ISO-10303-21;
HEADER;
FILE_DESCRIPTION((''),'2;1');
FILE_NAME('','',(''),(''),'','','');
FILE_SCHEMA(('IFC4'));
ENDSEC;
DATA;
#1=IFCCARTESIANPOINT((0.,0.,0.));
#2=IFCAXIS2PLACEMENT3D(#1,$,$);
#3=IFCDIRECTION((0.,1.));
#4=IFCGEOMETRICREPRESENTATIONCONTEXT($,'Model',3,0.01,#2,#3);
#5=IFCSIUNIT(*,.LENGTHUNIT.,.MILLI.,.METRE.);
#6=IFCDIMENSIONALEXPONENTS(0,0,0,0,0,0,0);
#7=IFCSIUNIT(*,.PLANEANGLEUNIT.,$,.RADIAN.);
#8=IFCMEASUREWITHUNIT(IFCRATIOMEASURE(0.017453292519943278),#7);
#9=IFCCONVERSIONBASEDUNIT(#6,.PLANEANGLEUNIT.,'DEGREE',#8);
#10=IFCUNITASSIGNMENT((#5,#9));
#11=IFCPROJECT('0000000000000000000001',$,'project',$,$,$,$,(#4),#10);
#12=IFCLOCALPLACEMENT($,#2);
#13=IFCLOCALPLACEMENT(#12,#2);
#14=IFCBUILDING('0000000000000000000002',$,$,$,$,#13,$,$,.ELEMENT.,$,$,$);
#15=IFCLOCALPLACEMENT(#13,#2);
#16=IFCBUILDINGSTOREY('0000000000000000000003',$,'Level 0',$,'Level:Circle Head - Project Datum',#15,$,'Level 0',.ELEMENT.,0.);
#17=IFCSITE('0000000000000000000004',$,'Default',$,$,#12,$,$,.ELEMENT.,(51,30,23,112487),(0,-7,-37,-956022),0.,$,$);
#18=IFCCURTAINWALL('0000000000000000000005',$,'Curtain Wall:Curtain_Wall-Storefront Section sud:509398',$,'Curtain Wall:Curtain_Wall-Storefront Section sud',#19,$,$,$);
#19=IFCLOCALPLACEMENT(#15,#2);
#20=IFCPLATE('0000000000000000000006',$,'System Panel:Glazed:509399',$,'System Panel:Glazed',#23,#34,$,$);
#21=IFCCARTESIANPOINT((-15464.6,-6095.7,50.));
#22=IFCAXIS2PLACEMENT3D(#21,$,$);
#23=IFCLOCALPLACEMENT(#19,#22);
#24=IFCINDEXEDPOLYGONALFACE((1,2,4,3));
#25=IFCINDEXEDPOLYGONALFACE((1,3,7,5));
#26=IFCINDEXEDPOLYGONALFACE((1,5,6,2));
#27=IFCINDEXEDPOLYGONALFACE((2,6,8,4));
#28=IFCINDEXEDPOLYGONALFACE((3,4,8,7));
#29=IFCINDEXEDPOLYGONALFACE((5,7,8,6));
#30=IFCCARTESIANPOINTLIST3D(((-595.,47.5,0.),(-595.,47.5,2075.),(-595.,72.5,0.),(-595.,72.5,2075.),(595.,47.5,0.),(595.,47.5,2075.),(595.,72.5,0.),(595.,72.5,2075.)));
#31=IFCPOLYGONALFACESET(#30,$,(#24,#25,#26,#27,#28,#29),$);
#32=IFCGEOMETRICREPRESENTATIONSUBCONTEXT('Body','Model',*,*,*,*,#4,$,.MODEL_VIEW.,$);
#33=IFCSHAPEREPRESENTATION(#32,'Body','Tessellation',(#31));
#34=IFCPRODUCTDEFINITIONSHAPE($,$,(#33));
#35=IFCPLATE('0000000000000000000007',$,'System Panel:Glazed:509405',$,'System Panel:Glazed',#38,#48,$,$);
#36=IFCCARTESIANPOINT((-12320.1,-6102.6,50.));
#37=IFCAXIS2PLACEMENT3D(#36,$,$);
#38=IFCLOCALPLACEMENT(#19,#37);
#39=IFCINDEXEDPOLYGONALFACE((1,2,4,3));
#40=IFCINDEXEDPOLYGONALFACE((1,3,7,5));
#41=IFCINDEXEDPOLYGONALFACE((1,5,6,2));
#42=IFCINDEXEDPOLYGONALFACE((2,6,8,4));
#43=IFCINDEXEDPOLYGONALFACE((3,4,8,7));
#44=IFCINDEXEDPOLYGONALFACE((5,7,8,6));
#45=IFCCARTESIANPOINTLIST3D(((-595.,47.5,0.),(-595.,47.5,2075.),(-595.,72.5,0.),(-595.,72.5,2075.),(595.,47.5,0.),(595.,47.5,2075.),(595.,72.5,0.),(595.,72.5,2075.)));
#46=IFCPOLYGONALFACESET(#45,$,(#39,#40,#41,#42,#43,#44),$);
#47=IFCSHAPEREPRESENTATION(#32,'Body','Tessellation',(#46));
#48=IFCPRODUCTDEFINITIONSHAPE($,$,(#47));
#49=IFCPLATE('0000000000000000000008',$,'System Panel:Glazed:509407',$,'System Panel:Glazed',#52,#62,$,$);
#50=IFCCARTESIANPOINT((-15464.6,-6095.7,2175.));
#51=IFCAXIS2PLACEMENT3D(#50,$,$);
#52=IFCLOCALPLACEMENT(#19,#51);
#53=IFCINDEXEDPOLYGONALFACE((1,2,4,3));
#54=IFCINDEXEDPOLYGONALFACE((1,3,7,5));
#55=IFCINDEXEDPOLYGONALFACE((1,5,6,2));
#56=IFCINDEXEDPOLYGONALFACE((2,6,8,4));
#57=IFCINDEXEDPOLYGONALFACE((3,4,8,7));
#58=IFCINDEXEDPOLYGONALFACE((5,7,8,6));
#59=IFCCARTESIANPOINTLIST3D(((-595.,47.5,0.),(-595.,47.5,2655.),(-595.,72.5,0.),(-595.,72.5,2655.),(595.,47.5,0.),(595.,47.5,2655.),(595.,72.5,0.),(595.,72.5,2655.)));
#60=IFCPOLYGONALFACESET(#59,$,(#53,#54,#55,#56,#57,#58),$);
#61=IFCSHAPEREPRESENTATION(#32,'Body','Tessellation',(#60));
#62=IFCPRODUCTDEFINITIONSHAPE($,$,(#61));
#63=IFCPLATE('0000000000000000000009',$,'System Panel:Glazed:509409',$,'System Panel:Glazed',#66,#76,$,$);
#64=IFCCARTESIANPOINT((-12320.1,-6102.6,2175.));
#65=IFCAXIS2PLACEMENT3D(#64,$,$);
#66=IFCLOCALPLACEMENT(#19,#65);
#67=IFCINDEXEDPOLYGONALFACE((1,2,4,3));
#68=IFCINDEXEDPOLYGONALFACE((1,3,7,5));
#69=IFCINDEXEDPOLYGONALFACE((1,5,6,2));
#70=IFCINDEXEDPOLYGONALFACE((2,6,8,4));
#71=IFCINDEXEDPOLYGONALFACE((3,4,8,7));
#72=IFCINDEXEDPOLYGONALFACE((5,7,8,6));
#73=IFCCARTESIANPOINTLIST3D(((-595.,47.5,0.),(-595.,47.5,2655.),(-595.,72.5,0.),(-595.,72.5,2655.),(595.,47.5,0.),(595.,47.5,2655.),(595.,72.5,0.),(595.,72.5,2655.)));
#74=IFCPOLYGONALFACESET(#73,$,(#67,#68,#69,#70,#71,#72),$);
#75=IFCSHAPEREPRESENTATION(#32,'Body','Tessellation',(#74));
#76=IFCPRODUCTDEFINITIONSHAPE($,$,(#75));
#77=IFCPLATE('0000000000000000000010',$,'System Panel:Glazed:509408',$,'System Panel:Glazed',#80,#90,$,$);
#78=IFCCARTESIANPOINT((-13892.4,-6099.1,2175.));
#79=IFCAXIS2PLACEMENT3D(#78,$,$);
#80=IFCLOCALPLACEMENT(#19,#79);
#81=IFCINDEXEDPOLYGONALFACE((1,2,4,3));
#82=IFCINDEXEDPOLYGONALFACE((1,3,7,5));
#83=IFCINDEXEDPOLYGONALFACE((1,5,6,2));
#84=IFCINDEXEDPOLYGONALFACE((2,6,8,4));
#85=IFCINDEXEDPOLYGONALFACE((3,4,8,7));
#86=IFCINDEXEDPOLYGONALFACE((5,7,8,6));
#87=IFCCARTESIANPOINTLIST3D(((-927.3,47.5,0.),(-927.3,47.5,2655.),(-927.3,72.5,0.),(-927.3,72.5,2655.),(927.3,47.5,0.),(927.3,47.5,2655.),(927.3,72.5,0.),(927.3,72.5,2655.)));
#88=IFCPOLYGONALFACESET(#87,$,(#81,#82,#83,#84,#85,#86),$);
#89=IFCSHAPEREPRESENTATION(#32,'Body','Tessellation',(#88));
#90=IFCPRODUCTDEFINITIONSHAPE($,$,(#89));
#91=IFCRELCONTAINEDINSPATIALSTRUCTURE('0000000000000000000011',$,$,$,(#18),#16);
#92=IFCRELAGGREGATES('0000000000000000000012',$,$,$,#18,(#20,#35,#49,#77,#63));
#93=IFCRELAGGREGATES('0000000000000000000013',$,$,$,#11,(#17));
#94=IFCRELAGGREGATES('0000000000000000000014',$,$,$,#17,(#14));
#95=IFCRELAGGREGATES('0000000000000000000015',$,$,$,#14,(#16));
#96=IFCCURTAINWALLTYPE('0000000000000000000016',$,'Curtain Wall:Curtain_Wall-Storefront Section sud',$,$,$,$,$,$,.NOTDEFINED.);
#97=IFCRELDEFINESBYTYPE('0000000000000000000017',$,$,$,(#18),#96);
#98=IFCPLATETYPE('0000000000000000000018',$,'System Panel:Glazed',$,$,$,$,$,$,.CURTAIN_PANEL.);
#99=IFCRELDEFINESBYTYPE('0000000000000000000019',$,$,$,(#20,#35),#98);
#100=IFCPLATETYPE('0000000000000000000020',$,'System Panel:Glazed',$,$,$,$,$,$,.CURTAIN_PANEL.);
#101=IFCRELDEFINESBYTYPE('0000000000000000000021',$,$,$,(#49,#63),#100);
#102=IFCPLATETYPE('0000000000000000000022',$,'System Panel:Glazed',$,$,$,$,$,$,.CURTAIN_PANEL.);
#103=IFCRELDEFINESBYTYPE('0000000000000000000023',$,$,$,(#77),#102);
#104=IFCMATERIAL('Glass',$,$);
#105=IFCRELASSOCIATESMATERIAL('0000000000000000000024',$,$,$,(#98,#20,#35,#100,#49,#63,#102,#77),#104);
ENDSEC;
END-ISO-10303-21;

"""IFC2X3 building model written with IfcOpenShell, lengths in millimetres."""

from ifc_helpers import new_model, entity, si_unit, converted_unit, direction, frame, frame_2d, origin, origin_2d_with_axis, place, context, subcontext, project, spatial, rectangle, extrude, source, transform, mapped, material, type_object, type_shapes, element, aggregate, save


model = new_model("IFC2X3")

# Units and contexts
model_context = context("Model", 3, precision=0.01, world=origin(), true_north=direction((0.0, 1.0)))
body_context = subcontext(model_context, "Body", "Model", "MODEL_VIEW")
ifc_project = project(units=[si_unit("LENGTHUNIT", "METRE", prefix="MILLI"), converted_unit("PLANEANGLEUNIT", "DEGREE", entity("IfcRatioMeasure", 0.017453292519943278), si_unit("PLANEANGLEUNIT", "RADIAN"), dimensions=[0, 0, 0, 0, 0, 0, 0])], contexts=[model_context])

# Site, building, storey
site_placement = place(None, origin())
site = spatial("IfcSite", under=ifc_project, at=site_placement, Name="Default", CompositionType="ELEMENT", RefLatitude=(51, 30, 23, 112487), RefLongitude=(0, -7, -37, -956022), RefElevation=0.0)
building_placement = place(site_placement, origin())
building = spatial("IfcBuilding", under=site, at=building_placement, CompositionType="ELEMENT")
storey_placement = place(building_placement, origin())
storey = spatial("IfcBuildingStorey", under=building, at=storey_placement, Name="Level 0", ObjectType="Level:Circle Head - Project Datum", LongName="Level 0", CompositionType="ELEMENT", Elevation=0.0)

# Curtain wall, plates
curtain_wall_type = type_object("IfcCurtainWallType", Name="Curtain Wall:Curtain_Wall-Storefront Section sud", PredefinedType="NOTDEFINED")
curtain_wall_placement = place(storey_placement, origin())
curtain_wall = element("IfcCurtainWall", 1, at=curtain_wall_placement, inside=storey, type_object=curtain_wall_type, Name="Curtain Wall:Curtain_Wall-Storefront Section sud:509398", ObjectType="Curtain Wall:Curtain_Wall-Storefront Section sud")
ifc_material_1 = material(Name="Glass")
plate_type_1 = type_object("IfcPlateType", Name="System Panel:Glazed", PredefinedType="CURTAIN_PANEL", material=ifc_material_1)
shared_shape_1 = source(origin(), body_context, "Body", "SweptSolid", [
    extrude(rectangle(XDim=25.0, YDim=1190.0, at=origin_2d_with_axis()), frame((0.0, 60.0, 0.0), z_axis=(0.0, 0.0, 1.0), x_axis=(0.0, 1.0, 0.0)), (0.0, 0.0, 1.0), 2075.0),
])
type_shapes(plate_type_1, [shared_shape_1])
plate_1_placement = place(curtain_wall_placement, frame((-15464.6, -6095.7, 50.0)))
plate_1 = element("IfcPlate", 2, at=plate_1_placement, type_object=plate_type_1, material=ifc_material_1, Name="System Panel:Glazed:509399", ObjectType="System Panel:Glazed", context=body_context, shape_type="MappedRepresentation", body=[
    mapped(shared_shape_1, transform((0.0, 0.0, 0.0), scale=1.0)),
])
plate_2_placement = place(curtain_wall_placement, frame((-12320.1, -6102.6, 50.0)))
plate_2 = element("IfcPlate", 3, at=plate_2_placement, type_object=plate_type_1, material=ifc_material_1, Name="System Panel:Glazed:509405", ObjectType="System Panel:Glazed", context=body_context, shape_type="MappedRepresentation", body=[
    mapped(shared_shape_1, transform((0.0, 0.0, 0.0), scale=1.0)),
])
plate_type_2 = type_object("IfcPlateType", Name="System Panel:Glazed", PredefinedType="CURTAIN_PANEL", material=ifc_material_1)
shared_shape_2 = source(origin(), body_context, "Body", "SweptSolid", [
    extrude(rectangle(XDim=25.0, YDim=1190.0, at=frame_2d((0.0, 0.0), x_axis=(1.0, 0.0))), frame((0.0, 60.0, 0.0), z_axis=(0.0, 0.0, 1.0), x_axis=(0.0, 1.0, 0.0)), (0.0, 0.0, 1.0), 2655.0),
])
type_shapes(plate_type_2, [shared_shape_2])
plate_3_placement = place(curtain_wall_placement, frame((-15464.6, -6095.7, 2175.0)))
plate_3 = element("IfcPlate", 4, at=plate_3_placement, type_object=plate_type_2, material=ifc_material_1, Name="System Panel:Glazed:509407", ObjectType="System Panel:Glazed", context=body_context, shape_type="MappedRepresentation", body=[
    mapped(shared_shape_2, transform((0.0, 0.0, 0.0), scale=1.0)),
])
plate_4_placement = place(curtain_wall_placement, frame((-12320.1, -6102.6, 2175.0)))
plate_4 = element("IfcPlate", 5, at=plate_4_placement, type_object=plate_type_2, material=ifc_material_1, Name="System Panel:Glazed:509409", ObjectType="System Panel:Glazed", context=body_context, shape_type="MappedRepresentation", body=[
    mapped(shared_shape_2, transform((0.0, 0.0, 0.0), scale=1.0)),
])
plate_type_3 = type_object("IfcPlateType", Name="System Panel:Glazed", PredefinedType="CURTAIN_PANEL", material=ifc_material_1)
shared_shape_3 = source(origin(), body_context, "Body", "SweptSolid", [
    extrude(rectangle(XDim=25.0, YDim=1854.5, at=frame_2d((0.0, 0.0), x_axis=(1.0, 0.0))), frame((0.0, 60.0, 0.0), z_axis=(0.0, 0.0, 1.0), x_axis=(0.0, 1.0, 0.0)), (0.0, 0.0, 1.0), 2655.0),
])
type_shapes(plate_type_3, [shared_shape_3])
plate_5_placement = place(curtain_wall_placement, frame((-13892.4, -6099.1, 2175.0)))
plate_5 = element("IfcPlate", 6, at=plate_5_placement, type_object=plate_type_3, material=ifc_material_1, Name="System Panel:Glazed:509408", ObjectType="System Panel:Glazed", context=body_context, shape_type="MappedRepresentation", body=[
    mapped(shared_shape_3, transform((0.0, 0.0, 0.0), scale=1.0)),
])
aggregate(curtain_wall, [plate_1, plate_2, plate_3, plate_5, plate_4])

save(model, "model.ifc")
